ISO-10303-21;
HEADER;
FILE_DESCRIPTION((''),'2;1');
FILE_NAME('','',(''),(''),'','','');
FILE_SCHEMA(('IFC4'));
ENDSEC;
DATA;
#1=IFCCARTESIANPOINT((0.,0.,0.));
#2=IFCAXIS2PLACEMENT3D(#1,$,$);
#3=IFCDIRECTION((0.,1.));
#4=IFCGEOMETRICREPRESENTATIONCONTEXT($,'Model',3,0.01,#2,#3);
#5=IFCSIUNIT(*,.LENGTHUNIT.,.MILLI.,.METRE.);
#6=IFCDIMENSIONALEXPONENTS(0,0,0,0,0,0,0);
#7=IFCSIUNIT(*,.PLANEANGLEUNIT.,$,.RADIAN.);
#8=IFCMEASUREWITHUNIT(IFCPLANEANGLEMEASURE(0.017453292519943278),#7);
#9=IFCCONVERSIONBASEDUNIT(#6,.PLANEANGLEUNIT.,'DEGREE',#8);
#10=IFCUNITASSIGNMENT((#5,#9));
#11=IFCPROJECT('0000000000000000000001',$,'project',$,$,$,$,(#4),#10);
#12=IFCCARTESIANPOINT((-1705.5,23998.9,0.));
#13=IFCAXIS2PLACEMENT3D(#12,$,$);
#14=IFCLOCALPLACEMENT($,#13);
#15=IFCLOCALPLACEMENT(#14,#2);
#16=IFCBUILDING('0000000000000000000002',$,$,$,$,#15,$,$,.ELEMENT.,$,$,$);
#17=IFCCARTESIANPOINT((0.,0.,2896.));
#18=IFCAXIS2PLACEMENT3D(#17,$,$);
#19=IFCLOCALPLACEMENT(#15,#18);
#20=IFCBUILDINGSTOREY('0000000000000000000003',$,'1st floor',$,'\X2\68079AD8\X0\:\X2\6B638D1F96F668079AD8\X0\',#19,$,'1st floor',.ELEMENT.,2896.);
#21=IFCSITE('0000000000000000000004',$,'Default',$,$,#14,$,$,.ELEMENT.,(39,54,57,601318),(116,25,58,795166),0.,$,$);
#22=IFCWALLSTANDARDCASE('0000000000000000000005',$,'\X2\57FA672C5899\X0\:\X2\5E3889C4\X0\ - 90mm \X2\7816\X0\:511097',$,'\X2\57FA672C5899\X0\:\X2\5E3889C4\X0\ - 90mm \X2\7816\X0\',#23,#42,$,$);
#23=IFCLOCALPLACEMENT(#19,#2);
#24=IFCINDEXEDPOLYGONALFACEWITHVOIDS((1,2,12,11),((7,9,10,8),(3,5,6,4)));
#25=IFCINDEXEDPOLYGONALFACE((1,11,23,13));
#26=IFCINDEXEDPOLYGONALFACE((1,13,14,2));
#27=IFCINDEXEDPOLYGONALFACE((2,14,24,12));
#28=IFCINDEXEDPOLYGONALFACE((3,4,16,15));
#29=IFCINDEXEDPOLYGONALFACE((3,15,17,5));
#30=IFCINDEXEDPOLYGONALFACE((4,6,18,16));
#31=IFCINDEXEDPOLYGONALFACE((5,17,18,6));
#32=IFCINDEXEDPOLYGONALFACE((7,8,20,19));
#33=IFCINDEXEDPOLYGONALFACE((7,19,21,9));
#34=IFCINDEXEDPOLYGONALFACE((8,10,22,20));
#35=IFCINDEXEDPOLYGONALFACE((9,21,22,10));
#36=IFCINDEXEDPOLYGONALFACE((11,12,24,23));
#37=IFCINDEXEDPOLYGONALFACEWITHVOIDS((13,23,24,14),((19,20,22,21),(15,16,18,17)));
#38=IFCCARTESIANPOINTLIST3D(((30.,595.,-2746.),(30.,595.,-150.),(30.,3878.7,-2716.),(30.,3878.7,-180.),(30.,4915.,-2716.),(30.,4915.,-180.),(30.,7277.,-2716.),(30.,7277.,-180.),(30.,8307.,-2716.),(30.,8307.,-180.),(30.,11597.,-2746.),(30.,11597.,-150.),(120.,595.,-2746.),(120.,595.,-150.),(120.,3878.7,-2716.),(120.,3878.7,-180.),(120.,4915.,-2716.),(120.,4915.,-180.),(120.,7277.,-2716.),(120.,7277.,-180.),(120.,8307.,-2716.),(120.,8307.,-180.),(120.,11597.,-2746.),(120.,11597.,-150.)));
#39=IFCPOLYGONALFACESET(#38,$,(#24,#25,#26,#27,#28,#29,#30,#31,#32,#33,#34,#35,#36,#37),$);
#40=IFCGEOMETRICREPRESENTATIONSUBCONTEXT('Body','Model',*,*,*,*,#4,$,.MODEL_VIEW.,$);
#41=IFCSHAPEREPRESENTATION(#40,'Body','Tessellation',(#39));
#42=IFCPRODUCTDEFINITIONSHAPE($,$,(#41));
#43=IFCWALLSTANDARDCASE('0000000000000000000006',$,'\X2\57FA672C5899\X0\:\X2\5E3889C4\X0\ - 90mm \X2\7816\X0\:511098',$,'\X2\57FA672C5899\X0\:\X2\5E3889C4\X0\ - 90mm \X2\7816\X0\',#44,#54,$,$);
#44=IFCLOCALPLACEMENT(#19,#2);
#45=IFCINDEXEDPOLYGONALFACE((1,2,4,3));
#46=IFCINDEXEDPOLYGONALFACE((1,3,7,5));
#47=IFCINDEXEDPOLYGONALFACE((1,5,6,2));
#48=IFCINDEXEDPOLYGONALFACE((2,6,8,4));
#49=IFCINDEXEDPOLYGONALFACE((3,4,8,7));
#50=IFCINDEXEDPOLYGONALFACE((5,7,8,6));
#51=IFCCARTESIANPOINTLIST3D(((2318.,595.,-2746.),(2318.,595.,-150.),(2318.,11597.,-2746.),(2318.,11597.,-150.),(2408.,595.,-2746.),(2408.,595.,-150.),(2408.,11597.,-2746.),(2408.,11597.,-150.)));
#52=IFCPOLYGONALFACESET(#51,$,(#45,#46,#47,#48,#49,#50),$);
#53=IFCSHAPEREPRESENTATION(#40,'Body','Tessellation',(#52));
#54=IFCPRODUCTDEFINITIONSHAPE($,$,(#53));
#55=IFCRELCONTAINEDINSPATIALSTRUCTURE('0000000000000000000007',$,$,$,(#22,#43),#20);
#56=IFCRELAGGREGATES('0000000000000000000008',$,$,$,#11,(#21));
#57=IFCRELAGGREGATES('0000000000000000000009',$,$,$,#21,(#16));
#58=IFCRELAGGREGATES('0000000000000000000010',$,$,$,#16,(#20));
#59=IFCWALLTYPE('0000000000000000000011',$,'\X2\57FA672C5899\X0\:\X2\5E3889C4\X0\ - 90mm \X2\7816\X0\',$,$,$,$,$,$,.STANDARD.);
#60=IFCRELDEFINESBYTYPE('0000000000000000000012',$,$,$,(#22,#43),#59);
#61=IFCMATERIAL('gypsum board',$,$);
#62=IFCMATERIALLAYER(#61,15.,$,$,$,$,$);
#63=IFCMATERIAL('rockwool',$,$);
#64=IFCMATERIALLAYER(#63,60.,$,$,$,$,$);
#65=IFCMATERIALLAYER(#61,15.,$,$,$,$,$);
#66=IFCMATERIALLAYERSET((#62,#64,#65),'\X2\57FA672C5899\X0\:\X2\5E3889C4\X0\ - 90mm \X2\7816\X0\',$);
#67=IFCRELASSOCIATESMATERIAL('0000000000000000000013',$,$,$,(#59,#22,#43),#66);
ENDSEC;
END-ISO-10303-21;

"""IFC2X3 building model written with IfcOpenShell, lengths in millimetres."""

from ifc_helpers import new_model, entity, si_unit, converted_unit, direction, frame, frame_2d, origin, place, context, subcontext, project, spatial, rectangle, extrude, material, layer, layer_set, layer_usage, type_object, element, save


model = new_model("IFC2X3")

# Units and contexts
model_context = context("Model", 3, precision=0.01, world=origin(), true_north=direction((0.0, 1.0)))
body_context = subcontext(model_context, "Body", "Model", "MODEL_VIEW")
ifc_project = project(units=[si_unit("LENGTHUNIT", "METRE", prefix="MILLI"), converted_unit("PLANEANGLEUNIT", "DEGREE", entity("IfcPlaneAngleMeasure", 0.017453292519943278), si_unit("PLANEANGLEUNIT", "RADIAN"), dimensions=[0, 0, 0, 0, 0, 0, 0])], contexts=[model_context])

# Site, building, storey
site_placement = place(None, frame((-1705.5, 23998.9, 0.0)))
site = spatial("IfcSite", under=ifc_project, at=site_placement, Name="Default", CompositionType="ELEMENT", RefLatitude=(39, 54, 57, 601318), RefLongitude=(116, 25, 58, 795166), RefElevation=0.0)
building_placement = place(site_placement, origin())
building = spatial("IfcBuilding", under=site, at=building_placement, CompositionType="ELEMENT")
storey_placement = place(building_placement, frame((0.0, 0.0, 2896.0)))
storey = spatial("IfcBuildingStorey", under=building, at=storey_placement, Name="1st floor", ObjectType="标高:正负零标高", LongName="1st floor", CompositionType="ELEMENT", Elevation=2896.0)

# Wall, openings
ifc_material_1 = material(Name="gypsum board")
ifc_layer_1 = layer(ifc_material_1, 15.0)
ifc_material_2 = material(Name="rockwool")
ifc_layer_2 = layer(ifc_material_2, 60.0)
ifc_layer_3 = layer(ifc_material_1, 15.0)
ifc_layer_set = layer_set([ifc_layer_1, ifc_layer_2, ifc_layer_3], Name="基本墙:常规 - 90mm 砖")
ifc_layer_usage_1 = layer_usage(ifc_layer_set, "AXIS2", "NEGATIVE", 45.0)
wall_type = type_object("IfcWallType", Name="基本墙:常规 - 90mm 砖", PredefinedType="STANDARD", material=ifc_layer_set)
wall_1_placement = place(storey_placement, frame((75.0, 11597.0, -2746.0), z_axis=(0.0, 0.0, 1.0), x_axis=(0.0, -1.0, 0.0)))
wall_1 = element("IfcWallStandardCase", 1, at=wall_1_placement, inside=storey, type_object=wall_type, material=ifc_layer_usage_1, Name="基本墙:常规 - 90mm 砖:511097", ObjectType="基本墙:常规 - 90mm 砖", context=body_context, shape_type="SweptSolid", body=[
    extrude(rectangle(XDim=11002.0, YDim=90.0, at=frame_2d((5501.0, 0.0), x_axis=(-1.0, 0.0))), origin(), (0.0, 0.0, 1.0), 2596.0),
])
opening_1_placement = place(wall_1_placement, origin())
element("IfcOpeningElement", 2, at=opening_1_placement, cuts=wall_1, ObjectType="Opening", context=body_context, shape_type="SweptSolid", body=[
    extrude(rectangle(XDim=2536.0, YDim=1030.0, at=frame_2d((0.0, 0.0), x_axis=(0.0, 1.0))), frame((3805.0, 45.0, 1298.0), z_axis=(0.0, -1.0, 0.0), x_axis=(-1.0, 0.0, 0.0)), (0.0, 0.0, 1.0), 90.0),
])
opening_2_placement = place(wall_1_placement, origin())
element("IfcOpeningElement", 3, at=opening_2_placement, cuts=wall_1, ObjectType="Opening", context=body_context, shape_type="SweptSolid", body=[
    extrude(rectangle(XDim=2536.0, YDim=1036.3, at=frame_2d((0.0, 0.0), x_axis=(0.0, 1.0))), frame((7200.2, 45.0, 1298.0), z_axis=(0.0, -1.0, 0.0), x_axis=(-1.0, 0.0, 0.0)), (0.0, 0.0, 1.0), 90.0),
])

# Wall
ifc_layer_usage_2 = layer_usage(ifc_layer_set, "AXIS2", "NEGATIVE", 45.0)
wall_2_placement = place(storey_placement, frame((2363.0, 11597.0, -2746.0), z_axis=(0.0, 0.0, 1.0), x_axis=(0.0, -1.0, 0.0)))
element("IfcWallStandardCase", 4, at=wall_2_placement, inside=storey, type_object=wall_type, material=ifc_layer_usage_2, Name="基本墙:常规 - 90mm 砖:511098", ObjectType="基本墙:常规 - 90mm 砖", context=body_context, shape_type="SweptSolid", body=[
    extrude(rectangle(XDim=11002.0, YDim=90.0, at=frame_2d((5501.0, 0.0), x_axis=(-1.0, 0.0))), origin(), (0.0, 0.0, 1.0), 2596.0),
])

save(model, "model.ifc")
